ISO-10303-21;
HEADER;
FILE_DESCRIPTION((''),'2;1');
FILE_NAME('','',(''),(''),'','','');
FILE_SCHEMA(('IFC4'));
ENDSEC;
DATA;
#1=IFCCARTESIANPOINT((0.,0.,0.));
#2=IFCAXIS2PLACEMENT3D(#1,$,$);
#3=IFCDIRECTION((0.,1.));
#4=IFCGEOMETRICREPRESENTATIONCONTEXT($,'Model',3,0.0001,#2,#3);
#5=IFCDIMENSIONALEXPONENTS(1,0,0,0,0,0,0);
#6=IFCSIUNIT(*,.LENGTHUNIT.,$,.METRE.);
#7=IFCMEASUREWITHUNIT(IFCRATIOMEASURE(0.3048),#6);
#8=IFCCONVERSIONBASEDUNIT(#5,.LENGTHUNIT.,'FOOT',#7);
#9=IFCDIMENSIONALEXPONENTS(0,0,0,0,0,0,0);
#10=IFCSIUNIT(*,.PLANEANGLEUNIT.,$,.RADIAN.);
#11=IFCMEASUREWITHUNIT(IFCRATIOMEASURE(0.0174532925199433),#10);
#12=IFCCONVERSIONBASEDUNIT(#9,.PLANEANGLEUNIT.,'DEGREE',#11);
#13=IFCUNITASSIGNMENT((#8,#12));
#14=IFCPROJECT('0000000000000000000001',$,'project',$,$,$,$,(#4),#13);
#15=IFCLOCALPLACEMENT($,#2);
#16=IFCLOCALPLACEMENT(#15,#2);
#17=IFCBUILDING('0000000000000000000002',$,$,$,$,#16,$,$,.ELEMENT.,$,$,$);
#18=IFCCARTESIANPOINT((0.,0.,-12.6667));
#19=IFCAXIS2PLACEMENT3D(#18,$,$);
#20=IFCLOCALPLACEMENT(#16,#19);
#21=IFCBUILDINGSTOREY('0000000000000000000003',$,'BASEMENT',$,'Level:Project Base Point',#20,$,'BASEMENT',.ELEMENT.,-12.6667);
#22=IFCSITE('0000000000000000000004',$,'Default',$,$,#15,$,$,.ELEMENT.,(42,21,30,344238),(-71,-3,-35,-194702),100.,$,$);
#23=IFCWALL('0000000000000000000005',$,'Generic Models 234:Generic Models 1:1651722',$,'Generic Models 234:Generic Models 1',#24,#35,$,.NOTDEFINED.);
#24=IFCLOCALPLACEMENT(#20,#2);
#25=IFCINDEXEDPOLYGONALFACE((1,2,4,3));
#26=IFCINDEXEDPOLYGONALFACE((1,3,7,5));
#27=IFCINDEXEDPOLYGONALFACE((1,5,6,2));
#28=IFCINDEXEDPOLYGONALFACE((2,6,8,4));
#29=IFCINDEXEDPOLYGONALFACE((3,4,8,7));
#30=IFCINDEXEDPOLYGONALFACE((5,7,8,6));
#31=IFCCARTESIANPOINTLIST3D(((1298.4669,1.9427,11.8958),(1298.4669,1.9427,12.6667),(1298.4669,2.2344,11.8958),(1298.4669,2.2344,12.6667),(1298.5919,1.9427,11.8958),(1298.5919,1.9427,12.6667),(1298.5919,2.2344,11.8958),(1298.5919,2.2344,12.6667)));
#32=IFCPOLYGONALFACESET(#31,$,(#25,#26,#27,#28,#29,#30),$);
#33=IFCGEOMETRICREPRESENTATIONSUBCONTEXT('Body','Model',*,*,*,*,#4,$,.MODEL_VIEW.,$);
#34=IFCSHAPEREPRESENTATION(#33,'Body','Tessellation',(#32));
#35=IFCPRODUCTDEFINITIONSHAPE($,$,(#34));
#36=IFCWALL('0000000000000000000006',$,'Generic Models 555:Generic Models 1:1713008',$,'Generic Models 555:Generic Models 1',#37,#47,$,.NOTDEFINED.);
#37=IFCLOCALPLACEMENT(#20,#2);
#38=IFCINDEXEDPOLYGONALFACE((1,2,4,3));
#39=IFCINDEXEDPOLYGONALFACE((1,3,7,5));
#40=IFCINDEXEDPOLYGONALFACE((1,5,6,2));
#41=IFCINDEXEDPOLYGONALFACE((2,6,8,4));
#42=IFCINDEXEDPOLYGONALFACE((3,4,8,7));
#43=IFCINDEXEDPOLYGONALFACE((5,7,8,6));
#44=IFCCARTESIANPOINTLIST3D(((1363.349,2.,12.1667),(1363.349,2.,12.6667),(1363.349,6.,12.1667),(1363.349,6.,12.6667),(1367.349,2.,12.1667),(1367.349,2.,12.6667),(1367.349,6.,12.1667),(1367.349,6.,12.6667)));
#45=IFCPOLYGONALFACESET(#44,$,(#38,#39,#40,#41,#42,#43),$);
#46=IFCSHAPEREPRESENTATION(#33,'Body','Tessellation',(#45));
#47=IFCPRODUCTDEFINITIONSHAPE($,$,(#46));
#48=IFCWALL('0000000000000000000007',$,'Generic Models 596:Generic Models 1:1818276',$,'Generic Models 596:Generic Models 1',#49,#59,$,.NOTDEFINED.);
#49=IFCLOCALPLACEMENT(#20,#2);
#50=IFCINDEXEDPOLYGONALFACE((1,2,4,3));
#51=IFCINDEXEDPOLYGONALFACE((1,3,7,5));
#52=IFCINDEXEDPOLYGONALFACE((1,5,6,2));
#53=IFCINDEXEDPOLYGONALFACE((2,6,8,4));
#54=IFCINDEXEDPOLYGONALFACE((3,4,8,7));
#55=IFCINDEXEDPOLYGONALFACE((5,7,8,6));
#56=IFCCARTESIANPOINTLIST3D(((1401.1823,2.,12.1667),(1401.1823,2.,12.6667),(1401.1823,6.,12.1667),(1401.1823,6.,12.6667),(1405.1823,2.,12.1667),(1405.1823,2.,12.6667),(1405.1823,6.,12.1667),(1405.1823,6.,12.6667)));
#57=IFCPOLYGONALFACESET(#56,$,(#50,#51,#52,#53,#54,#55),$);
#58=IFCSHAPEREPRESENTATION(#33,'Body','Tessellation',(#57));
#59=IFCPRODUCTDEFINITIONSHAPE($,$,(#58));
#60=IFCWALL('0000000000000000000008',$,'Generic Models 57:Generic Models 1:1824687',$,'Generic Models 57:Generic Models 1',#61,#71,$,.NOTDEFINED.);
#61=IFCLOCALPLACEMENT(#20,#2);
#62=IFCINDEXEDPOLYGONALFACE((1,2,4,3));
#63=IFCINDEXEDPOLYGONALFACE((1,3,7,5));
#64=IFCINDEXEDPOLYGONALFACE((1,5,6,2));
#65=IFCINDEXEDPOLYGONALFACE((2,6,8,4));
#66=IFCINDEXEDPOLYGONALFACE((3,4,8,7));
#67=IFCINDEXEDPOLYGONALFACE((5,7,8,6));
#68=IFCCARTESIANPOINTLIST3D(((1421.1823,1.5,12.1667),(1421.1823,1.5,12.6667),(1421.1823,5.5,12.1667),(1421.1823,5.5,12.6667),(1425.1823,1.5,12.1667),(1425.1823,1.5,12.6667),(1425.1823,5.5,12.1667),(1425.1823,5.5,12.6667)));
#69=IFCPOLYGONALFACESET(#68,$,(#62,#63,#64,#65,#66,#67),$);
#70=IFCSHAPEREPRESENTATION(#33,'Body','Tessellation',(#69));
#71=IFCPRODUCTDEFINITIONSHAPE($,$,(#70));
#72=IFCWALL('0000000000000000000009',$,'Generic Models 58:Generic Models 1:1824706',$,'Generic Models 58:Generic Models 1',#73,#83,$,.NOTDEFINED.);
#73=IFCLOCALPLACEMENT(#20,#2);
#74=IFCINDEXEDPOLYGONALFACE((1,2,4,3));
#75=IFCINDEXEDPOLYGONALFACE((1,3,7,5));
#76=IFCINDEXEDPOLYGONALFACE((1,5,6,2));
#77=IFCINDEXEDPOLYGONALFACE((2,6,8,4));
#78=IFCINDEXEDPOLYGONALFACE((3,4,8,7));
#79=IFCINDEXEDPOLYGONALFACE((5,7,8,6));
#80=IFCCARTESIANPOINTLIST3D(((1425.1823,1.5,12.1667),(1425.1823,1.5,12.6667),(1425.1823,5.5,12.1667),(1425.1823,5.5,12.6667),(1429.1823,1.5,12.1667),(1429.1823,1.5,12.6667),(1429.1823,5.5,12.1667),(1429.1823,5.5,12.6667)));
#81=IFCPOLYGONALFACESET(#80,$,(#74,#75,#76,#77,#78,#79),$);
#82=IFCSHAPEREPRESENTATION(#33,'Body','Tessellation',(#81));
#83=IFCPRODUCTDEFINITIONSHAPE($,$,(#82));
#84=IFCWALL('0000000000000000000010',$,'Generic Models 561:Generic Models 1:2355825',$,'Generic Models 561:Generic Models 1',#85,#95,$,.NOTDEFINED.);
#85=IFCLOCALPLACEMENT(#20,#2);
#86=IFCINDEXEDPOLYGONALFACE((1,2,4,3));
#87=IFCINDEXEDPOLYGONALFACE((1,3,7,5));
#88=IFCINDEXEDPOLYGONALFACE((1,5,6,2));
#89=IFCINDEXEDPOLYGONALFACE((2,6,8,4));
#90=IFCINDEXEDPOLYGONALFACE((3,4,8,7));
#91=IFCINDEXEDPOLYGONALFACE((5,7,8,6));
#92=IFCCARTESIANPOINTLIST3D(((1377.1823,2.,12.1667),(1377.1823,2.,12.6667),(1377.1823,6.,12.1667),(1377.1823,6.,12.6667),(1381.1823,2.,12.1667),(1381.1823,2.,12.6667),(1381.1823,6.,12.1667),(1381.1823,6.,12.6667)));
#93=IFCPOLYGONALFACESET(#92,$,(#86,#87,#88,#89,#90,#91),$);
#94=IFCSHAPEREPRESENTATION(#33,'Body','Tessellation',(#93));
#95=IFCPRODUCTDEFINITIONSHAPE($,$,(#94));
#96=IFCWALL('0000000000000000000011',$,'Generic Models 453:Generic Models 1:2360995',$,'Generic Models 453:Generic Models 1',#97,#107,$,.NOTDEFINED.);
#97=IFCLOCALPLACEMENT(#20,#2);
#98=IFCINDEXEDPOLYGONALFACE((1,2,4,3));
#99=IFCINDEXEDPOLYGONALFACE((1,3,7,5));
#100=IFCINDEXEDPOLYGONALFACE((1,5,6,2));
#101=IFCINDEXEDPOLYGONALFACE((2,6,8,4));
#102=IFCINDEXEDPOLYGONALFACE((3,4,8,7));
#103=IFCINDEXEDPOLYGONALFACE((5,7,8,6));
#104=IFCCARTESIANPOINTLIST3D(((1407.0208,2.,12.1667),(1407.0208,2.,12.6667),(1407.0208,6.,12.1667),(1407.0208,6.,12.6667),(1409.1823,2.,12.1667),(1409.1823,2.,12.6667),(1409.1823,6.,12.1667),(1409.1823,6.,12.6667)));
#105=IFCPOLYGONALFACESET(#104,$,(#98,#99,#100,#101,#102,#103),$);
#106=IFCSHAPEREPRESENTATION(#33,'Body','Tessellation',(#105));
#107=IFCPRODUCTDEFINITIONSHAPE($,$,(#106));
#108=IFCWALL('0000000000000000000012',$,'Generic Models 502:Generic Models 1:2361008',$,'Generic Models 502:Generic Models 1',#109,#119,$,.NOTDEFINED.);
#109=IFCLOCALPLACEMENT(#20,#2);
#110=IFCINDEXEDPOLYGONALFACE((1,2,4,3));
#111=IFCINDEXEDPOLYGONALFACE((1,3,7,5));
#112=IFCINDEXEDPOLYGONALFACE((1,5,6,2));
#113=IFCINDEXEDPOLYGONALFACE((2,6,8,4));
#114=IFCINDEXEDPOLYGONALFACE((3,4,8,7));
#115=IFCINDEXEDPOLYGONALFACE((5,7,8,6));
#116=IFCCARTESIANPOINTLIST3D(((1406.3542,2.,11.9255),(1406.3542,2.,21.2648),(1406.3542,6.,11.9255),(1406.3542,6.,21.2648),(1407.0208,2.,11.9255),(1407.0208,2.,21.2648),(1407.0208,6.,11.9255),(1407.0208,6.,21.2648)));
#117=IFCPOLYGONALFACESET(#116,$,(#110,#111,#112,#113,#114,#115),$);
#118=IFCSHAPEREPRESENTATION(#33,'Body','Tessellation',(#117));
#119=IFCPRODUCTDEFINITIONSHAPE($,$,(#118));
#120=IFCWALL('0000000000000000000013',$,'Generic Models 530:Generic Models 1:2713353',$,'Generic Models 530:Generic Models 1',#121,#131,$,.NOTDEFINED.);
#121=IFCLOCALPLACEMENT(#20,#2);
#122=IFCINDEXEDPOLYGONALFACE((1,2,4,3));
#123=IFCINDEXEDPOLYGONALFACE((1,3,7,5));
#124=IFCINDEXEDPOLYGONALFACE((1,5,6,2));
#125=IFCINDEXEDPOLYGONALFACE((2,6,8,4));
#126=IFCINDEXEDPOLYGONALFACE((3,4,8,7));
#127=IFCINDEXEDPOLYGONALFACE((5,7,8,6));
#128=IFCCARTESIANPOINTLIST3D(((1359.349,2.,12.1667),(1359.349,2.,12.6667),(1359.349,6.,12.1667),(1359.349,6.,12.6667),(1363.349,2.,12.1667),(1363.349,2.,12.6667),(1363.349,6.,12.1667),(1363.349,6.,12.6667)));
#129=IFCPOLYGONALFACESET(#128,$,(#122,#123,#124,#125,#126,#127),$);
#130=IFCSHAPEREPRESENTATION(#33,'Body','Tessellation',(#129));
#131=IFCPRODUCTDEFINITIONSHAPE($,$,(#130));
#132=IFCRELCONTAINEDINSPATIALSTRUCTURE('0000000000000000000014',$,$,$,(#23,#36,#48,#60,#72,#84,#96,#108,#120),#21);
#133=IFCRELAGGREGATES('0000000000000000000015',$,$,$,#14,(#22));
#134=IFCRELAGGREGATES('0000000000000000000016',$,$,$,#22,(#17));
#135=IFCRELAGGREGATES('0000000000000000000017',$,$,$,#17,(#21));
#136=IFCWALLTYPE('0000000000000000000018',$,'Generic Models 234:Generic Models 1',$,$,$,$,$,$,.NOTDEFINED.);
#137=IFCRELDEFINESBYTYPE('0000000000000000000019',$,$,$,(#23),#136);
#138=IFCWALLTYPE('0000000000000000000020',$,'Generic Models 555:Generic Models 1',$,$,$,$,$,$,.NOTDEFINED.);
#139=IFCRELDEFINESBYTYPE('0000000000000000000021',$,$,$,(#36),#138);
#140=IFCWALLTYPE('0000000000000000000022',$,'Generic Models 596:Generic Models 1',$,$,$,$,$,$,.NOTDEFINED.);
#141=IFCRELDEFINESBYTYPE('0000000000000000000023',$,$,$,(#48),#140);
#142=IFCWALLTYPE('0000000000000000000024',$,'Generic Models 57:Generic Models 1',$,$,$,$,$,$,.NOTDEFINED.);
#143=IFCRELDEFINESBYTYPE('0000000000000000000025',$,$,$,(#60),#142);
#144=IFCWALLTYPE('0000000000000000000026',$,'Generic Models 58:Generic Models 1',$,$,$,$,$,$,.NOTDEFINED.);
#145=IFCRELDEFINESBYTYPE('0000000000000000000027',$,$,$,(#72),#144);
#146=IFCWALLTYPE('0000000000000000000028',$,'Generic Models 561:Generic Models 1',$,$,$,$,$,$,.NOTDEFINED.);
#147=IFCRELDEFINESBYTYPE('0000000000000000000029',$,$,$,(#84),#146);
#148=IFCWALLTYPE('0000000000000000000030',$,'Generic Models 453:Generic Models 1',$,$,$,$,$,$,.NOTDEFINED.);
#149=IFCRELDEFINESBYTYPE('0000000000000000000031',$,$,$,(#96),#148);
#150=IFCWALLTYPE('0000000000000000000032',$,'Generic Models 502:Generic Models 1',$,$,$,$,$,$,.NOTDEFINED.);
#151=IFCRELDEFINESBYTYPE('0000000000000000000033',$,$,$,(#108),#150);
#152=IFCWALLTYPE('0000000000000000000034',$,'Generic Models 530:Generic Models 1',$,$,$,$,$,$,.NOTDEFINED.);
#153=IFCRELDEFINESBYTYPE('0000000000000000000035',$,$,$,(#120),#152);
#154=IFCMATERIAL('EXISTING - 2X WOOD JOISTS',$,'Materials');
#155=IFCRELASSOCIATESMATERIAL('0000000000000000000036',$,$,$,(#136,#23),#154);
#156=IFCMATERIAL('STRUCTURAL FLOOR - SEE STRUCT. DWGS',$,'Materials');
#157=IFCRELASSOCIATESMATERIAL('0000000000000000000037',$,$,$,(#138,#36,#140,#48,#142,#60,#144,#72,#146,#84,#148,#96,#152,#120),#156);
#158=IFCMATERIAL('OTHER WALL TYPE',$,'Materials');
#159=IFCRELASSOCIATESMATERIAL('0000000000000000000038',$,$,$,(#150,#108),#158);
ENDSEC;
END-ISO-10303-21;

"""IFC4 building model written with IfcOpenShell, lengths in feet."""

from ifc_helpers import new_model, entity, si_unit, converted_unit, direction, frame, frame_2d, origin, origin_2d_with_axis, place, context, subcontext, project, spatial, rectangle, extrude, material, type_object, element, save


model = new_model("IFC4")

# Units and contexts
model_context = context("Model", 3, precision=0.0001, world=origin(), true_north=direction((0.0, 1.0)))
body_context = subcontext(model_context, "Body", "Model", "MODEL_VIEW")
ifc_project = project(units=[converted_unit("LENGTHUNIT", "FOOT", entity("IfcRatioMeasure", 0.3048), si_unit("LENGTHUNIT", "METRE"), dimensions=[1, 0, 0, 0, 0, 0, 0]), converted_unit("PLANEANGLEUNIT", "DEGREE", entity("IfcRatioMeasure", 0.0174532925199433), si_unit("PLANEANGLEUNIT", "RADIAN"), dimensions=[0, 0, 0, 0, 0, 0, 0])], contexts=[model_context])

# Site, building, storey
site_placement = place(None, origin())
site = spatial("IfcSite", under=ifc_project, at=site_placement, Name="Default", CompositionType="ELEMENT", RefLatitude=(42, 21, 30, 344238), RefLongitude=(-71, -3, -35, -194702), RefElevation=100.0)
building_placement = place(site_placement, origin())
building = spatial("IfcBuilding", under=site, at=building_placement, CompositionType="ELEMENT")
storey_placement = place(building_placement, frame((0.0, 0.0, -12.6667)))
storey = spatial("IfcBuildingStorey", under=building, at=storey_placement, Name="BASEMENT", ObjectType="Level:Project Base Point", LongName="BASEMENT", CompositionType="ELEMENT", Elevation=-12.6667)

# Walls
ifc_material_1 = material(Name="STRUCTURAL FLOOR - SEE STRUCT. DWGS", Category="Materials")
ifc_material_2 = material(Name="OTHER WALL TYPE", Category="Materials")
ifc_material_3 = material(Name="EXISTING - 2X WOOD JOISTS", Category="Materials")
wall_type_1 = type_object("IfcWallType", Name="Generic Models 234:Generic Models 1", PredefinedType="NOTDEFINED", material=ifc_material_3)
wall_1_placement = place(storey_placement, frame((1298.4669, 1.9427, 11.8958), z_axis=(0.0, 0.0, 1.0), x_axis=(0.0, 1.0, 0.0)))
element("IfcWall", 1, at=wall_1_placement, inside=storey, type_object=wall_type_1, material=ifc_material_3, Name="Generic Models 234:Generic Models 1:1651722", ObjectType="Generic Models 234:Generic Models 1", PredefinedType="NOTDEFINED", context=body_context, shape_type="SweptSolid", body=[
    extrude(rectangle(XDim=0.2917, YDim=0.125, at=frame_2d((0.0, 0.0), x_axis=(1.0, 0.0))), frame((0.1458, -0.0625, 0.0)), (0.0, 0.0, 1.0), 0.7708),
])
wall_type_2 = type_object("IfcWallType", Name="Generic Models 555:Generic Models 1", PredefinedType="NOTDEFINED", material=ifc_material_1)
wall_2_placement = place(storey_placement, frame((1363.349, 2.0, 12.1667), z_axis=(0.0, 0.0, 1.0), x_axis=(0.0, 1.0, 0.0)))
element("IfcWall", 2, at=wall_2_placement, inside=storey, type_object=wall_type_2, material=ifc_material_1, Name="Generic Models 555:Generic Models 1:1713008", ObjectType="Generic Models 555:Generic Models 1", PredefinedType="NOTDEFINED", context=body_context, shape_type="SweptSolid", body=[
    extrude(rectangle(XDim=4.0, YDim=4.0, at=origin_2d_with_axis()), frame((2.0, -2.0, 0.0)), (0.0, 0.0, 1.0), 0.5),
])
wall_type_3 = type_object("IfcWallType", Name="Generic Models 596:Generic Models 1", PredefinedType="NOTDEFINED", material=ifc_material_1)
wall_3_placement = place(storey_placement, frame((1401.1823, 2.0, 12.1667), z_axis=(0.0, 0.0, 1.0), x_axis=(0.0, 1.0, 0.0)))
element("IfcWall", 3, at=wall_3_placement, inside=storey, type_object=wall_type_3, material=ifc_material_1, Name="Generic Models 596:Generic Models 1:1818276", ObjectType="Generic Models 596:Generic Models 1", PredefinedType="NOTDEFINED", context=body_context, shape_type="SweptSolid", body=[
    extrude(rectangle(XDim=4.0, YDim=4.0, at=origin_2d_with_axis()), frame((2.0, -2.0, 0.0)), (0.0, 0.0, 1.0), 0.5),
])
wall_type_4 = type_object("IfcWallType", Name="Generic Models 57:Generic Models 1", PredefinedType="NOTDEFINED", material=ifc_material_1)
wall_4_placement = place(storey_placement, frame((1421.1823, 1.5, 12.1667), z_axis=(0.0, 0.0, 1.0), x_axis=(0.0, 1.0, 0.0)))
element("IfcWall", 4, at=wall_4_placement, inside=storey, type_object=wall_type_4, material=ifc_material_1, Name="Generic Models 57:Generic Models 1:1824687", ObjectType="Generic Models 57:Generic Models 1", PredefinedType="NOTDEFINED", context=body_context, shape_type="SweptSolid", body=[
    extrude(rectangle(XDim=4.0, YDim=4.0, at=frame_2d((0.0, 0.0), x_axis=(1.0, 0.0))), frame((2.0, -2.0, 0.0)), (0.0, 0.0, 1.0), 0.5),
])
wall_type_5 = type_object("IfcWallType", Name="Generic Models 58:Generic Models 1", PredefinedType="NOTDEFINED", material=ifc_material_1)
wall_5_placement = place(storey_placement, frame((1425.1823, 1.5, 12.1667), z_axis=(0.0, 0.0, 1.0), x_axis=(0.0, 1.0, 0.0)))
element("IfcWall", 5, at=wall_5_placement, inside=storey, type_object=wall_type_5, material=ifc_material_1, Name="Generic Models 58:Generic Models 1:1824706", ObjectType="Generic Models 58:Generic Models 1", PredefinedType="NOTDEFINED", context=body_context, shape_type="SweptSolid", body=[
    extrude(rectangle(XDim=4.0, YDim=4.0, at=origin_2d_with_axis()), frame((2.0, -2.0, 0.0)), (0.0, 0.0, 1.0), 0.5),
])
wall_type_6 = type_object("IfcWallType", Name="Generic Models 561:Generic Models 1", PredefinedType="NOTDEFINED", material=ifc_material_1)
wall_6_placement = place(storey_placement, frame((1377.1823, 2.0, 12.1667), z_axis=(0.0, 0.0, 1.0), x_axis=(0.0, 1.0, 0.0)))
element("IfcWall", 6, at=wall_6_placement, inside=storey, type_object=wall_type_6, material=ifc_material_1, Name="Generic Models 561:Generic Models 1:2355825", ObjectType="Generic Models 561:Generic Models 1", PredefinedType="NOTDEFINED", context=body_context, shape_type="SweptSolid", body=[
    extrude(rectangle(XDim=4.0, YDim=4.0, at=frame_2d((0.0, 0.0), x_axis=(1.0, 0.0))), frame((2.0, -2.0, 0.0)), (0.0, 0.0, 1.0), 0.5),
])
wall_type_7 = type_object("IfcWallType", Name="Generic Models 453:Generic Models 1", PredefinedType="NOTDEFINED", material=ifc_material_1)
wall_7_placement = place(storey_placement, frame((1407.0208, 2.0, 12.1667), z_axis=(0.0, 0.0, 1.0), x_axis=(0.0, 1.0, 0.0)))
element("IfcWall", 7, at=wall_7_placement, inside=storey, type_object=wall_type_7, material=ifc_material_1, Name="Generic Models 453:Generic Models 1:2360995", ObjectType="Generic Models 453:Generic Models 1", PredefinedType="NOTDEFINED", context=body_context, shape_type="SweptSolid", body=[
    extrude(rectangle(XDim=4.0, YDim=2.1615, at=frame_2d((0.0, 0.0), x_axis=(1.0, 0.0))), frame((2.0, -1.0807, 0.0)), (0.0, 0.0, 1.0), 0.5),
])
wall_type_8 = type_object("IfcWallType", Name="Generic Models 502:Generic Models 1", PredefinedType="NOTDEFINED", material=ifc_material_2)
wall_8_placement = place(storey_placement, frame((1406.3542, 2.0, 11.9255), z_axis=(0.0, 0.0, 1.0), x_axis=(0.0, 1.0, 0.0)))
element("IfcWall", 8, at=wall_8_placement, inside=storey, type_object=wall_type_8, material=ifc_material_2, Name="Generic Models 502:Generic Models 1:2361008", ObjectType="Generic Models 502:Generic Models 1", PredefinedType="NOTDEFINED", context=body_context, shape_type="SweptSolid", body=[
    extrude(rectangle(XDim=4.0, YDim=0.6667, at=frame_2d((0.0, 0.0), x_axis=(1.0, 0.0))), frame((2.0, -0.3333, 0.0)), (0.0, 0.0, 1.0), 9.3393),
])
wall_type_9 = type_object("IfcWallType", Name="Generic Models 530:Generic Models 1", PredefinedType="NOTDEFINED", material=ifc_material_1)
wall_9_placement = place(storey_placement, frame((1359.349, 2.0, 12.1667), z_axis=(0.0, 0.0, 1.0), x_axis=(0.0, 1.0, 0.0)))
element("IfcWall", 9, at=wall_9_placement, inside=storey, type_object=wall_type_9, material=ifc_material_1, Name="Generic Models 530:Generic Models 1:2713353", ObjectType="Generic Models 530:Generic Models 1", PredefinedType="NOTDEFINED", context=body_context, shape_type="SweptSolid", body=[
    extrude(rectangle(XDim=4.0, YDim=4.0, at=origin_2d_with_axis()), frame((2.0, -2.0, 0.0)), (0.0, 0.0, 1.0), 0.5),
])

save(model, "model.ifc")
